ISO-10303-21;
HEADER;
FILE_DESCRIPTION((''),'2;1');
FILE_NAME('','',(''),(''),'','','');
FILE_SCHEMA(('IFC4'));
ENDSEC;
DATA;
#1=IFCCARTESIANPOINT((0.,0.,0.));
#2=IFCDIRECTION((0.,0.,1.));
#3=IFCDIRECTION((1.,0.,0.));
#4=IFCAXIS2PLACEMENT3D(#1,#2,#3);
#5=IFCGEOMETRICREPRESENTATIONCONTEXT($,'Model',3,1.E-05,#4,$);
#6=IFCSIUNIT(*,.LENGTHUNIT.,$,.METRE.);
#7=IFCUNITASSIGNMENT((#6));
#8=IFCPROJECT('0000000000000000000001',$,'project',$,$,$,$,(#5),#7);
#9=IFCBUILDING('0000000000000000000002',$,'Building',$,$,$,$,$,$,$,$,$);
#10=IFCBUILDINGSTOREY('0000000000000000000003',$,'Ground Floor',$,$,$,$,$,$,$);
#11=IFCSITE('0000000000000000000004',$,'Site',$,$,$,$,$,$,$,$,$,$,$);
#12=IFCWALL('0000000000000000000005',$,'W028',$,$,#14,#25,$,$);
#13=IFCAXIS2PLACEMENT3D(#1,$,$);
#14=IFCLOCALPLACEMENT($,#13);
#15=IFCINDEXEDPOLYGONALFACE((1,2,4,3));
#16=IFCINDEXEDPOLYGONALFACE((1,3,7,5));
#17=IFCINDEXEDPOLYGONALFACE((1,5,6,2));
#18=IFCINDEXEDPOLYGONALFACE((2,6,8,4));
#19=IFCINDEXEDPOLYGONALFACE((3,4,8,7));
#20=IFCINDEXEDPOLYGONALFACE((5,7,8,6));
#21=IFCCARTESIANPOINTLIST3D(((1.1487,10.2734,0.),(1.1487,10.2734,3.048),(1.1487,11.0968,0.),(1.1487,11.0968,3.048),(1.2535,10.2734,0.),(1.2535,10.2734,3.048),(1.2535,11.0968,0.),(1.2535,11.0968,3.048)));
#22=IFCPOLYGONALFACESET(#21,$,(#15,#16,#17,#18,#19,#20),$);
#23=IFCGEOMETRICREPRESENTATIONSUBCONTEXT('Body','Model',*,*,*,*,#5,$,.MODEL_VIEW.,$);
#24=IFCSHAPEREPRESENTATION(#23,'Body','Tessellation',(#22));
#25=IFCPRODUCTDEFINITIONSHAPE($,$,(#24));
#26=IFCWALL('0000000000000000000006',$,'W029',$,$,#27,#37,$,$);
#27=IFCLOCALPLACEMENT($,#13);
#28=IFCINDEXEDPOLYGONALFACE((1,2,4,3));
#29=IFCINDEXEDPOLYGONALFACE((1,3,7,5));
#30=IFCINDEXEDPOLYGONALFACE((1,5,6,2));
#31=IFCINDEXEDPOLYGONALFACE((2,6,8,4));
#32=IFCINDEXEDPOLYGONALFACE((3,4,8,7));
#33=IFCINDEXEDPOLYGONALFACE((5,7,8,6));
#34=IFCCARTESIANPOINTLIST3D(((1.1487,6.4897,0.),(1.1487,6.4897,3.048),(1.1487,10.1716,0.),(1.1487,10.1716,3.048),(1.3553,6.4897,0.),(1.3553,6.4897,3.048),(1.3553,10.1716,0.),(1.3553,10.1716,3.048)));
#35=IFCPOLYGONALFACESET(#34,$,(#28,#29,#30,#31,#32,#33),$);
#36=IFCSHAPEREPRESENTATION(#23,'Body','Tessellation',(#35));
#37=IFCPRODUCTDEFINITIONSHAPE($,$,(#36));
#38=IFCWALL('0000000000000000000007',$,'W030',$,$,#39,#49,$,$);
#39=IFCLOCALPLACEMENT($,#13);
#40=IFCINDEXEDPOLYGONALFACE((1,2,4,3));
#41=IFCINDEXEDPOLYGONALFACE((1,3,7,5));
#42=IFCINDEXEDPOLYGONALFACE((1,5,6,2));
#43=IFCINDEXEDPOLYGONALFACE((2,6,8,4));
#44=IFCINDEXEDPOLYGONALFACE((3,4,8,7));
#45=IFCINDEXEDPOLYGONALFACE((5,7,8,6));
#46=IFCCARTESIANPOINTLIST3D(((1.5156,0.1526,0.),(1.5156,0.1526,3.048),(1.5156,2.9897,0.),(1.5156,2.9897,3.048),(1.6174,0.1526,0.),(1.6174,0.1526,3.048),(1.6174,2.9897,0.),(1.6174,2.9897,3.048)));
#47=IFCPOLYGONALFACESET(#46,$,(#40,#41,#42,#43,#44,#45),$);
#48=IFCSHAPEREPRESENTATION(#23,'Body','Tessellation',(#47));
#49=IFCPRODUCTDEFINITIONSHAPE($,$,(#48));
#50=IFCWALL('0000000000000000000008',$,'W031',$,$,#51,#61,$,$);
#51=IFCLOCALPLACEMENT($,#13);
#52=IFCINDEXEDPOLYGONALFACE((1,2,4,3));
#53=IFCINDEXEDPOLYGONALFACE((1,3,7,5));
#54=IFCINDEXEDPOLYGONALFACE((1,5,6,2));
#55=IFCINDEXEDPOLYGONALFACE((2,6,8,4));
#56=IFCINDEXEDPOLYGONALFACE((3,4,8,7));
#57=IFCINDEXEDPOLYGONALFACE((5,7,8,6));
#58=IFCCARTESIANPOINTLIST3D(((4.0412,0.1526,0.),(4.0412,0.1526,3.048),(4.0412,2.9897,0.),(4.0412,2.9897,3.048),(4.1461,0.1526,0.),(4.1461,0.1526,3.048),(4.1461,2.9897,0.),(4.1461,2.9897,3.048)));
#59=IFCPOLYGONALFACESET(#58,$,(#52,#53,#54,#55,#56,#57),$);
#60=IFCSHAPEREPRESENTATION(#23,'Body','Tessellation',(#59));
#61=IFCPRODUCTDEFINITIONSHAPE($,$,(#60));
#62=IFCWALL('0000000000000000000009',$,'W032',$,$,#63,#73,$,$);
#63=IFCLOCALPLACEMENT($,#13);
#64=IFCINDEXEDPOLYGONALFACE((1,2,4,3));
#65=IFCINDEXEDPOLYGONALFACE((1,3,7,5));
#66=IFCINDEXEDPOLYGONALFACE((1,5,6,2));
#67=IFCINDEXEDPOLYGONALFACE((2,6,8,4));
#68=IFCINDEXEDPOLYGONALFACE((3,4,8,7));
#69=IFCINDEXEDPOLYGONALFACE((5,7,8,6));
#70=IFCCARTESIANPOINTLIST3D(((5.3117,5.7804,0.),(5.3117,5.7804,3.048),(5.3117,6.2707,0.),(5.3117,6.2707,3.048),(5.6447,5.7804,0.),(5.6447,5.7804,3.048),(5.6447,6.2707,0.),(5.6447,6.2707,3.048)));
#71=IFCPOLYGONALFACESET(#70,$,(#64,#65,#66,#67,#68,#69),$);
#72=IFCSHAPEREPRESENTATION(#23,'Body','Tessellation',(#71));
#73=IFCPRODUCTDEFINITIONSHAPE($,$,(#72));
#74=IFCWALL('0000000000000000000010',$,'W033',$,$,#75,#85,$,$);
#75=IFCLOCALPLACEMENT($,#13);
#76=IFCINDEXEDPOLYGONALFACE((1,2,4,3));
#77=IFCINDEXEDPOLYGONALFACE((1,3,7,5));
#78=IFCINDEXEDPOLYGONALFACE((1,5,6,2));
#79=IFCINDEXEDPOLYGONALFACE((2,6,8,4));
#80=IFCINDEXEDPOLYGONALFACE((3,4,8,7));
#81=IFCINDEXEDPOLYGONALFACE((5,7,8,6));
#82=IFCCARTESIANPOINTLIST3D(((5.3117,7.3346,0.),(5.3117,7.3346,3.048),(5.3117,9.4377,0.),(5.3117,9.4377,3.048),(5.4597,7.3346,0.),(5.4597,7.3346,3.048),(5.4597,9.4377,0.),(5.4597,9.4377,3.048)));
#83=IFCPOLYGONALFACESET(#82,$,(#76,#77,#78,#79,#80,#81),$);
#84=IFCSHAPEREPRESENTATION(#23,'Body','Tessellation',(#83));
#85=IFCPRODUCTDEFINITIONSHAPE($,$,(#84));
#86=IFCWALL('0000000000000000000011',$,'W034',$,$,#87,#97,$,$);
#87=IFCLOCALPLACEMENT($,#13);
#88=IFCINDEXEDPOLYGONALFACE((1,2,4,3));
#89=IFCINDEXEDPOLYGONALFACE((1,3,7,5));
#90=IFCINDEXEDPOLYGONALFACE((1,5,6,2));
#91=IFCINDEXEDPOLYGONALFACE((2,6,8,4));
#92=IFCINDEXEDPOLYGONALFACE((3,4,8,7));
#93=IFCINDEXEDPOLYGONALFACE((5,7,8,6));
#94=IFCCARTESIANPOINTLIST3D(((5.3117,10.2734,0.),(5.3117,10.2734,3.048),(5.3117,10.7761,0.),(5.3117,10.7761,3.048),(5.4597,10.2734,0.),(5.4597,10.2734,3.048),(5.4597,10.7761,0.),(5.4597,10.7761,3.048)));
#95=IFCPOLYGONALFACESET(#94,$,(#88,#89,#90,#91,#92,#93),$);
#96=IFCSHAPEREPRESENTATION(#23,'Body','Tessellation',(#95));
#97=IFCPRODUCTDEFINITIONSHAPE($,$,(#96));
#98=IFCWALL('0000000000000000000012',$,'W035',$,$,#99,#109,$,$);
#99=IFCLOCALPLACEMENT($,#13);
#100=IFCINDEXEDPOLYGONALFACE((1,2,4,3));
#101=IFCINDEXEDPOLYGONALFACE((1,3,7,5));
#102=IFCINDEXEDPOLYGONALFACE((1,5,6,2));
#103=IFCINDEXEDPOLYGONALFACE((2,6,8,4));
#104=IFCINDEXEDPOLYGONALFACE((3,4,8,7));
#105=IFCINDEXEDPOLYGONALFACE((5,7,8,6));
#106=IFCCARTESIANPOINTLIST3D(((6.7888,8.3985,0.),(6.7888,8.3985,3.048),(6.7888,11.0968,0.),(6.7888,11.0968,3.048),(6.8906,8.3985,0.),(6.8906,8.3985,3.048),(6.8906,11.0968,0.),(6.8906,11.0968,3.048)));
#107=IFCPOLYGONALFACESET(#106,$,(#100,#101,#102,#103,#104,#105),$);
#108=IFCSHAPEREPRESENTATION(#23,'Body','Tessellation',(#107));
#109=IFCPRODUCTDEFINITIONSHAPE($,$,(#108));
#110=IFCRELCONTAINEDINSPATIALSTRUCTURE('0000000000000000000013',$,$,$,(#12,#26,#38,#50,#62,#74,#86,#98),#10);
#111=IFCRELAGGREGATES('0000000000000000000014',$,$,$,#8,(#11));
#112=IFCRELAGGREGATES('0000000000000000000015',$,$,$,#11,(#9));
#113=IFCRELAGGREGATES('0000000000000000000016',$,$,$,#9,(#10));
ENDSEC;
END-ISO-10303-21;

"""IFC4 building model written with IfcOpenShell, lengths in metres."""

from ifc_helpers import new_model, si_unit, frame, origin_with_axes, place, context, subcontext, project, spatial, line, indexed_curve, outline, extrude, element, save


model = new_model("IFC4")

# Units and contexts
model_context = context("Model", 3, precision=1e-05, world=origin_with_axes())
body_context = subcontext(model_context, "Body", "Model", "MODEL_VIEW")
ifc_project = project(units=[si_unit("LENGTHUNIT", "METRE")], contexts=[model_context])

# Site, building, storey
site = spatial("IfcSite", under=ifc_project, Name="Site")
building = spatial("IfcBuilding", under=site, Name="Building")
storey = spatial("IfcBuildingStorey", under=building, Name="Ground Floor")

# Walls
wall_1_placement = place(None, frame((1.2011, 10.2734, 0.0), z_axis=(0.0, 0.0, 1.0), x_axis=(0.0, 1.0, 0.0)))
element("IfcWall", 1, at=wall_1_placement, inside=storey, Name="W028", context=body_context, shape_type="SweptSolid", body=[
    extrude(outline(indexed_curve([(0.0, -0.0524), (0.8234, -0.0524), (0.8234, 0.0524), (0.0, 0.0524)], segments=[line(1, 2, 3, 4, 1)])), origin_with_axes(), (0.0, 0.0, 1.0), 3.048),
])
wall_2_placement = place(None, frame((1.252, 6.4897, 0.0), z_axis=(0.0, 0.0, 1.0), x_axis=(0.0, 1.0, 0.0)))
element("IfcWall", 2, at=wall_2_placement, inside=storey, Name="W029", context=body_context, shape_type="SweptSolid", body=[
    extrude(outline(indexed_curve([(0.0, -0.1033), (3.682, -0.1033), (3.682, 0.1033), (0.0, 0.1033)], segments=[line(1, 2, 3, 4, 1)])), origin_with_axes(), (0.0, 0.0, 1.0), 3.048),
])
wall_3_placement = place(None, frame((1.5665, 0.1526, 0.0), z_axis=(0.0, 0.0, 1.0), x_axis=(0.0, 1.0, 0.0)))
element("IfcWall", 3, at=wall_3_placement, inside=storey, Name="W030", context=body_context, shape_type="SweptSolid", body=[
    extrude(outline(indexed_curve([(0.0, -0.0509), (2.837, -0.0509), (2.837, 0.0509), (0.0, 0.0509)], segments=[line(1, 2, 3, 4, 1)])), origin_with_axes(), (0.0, 0.0, 1.0), 3.048),
])
wall_4_placement = place(None, frame((4.0936, 0.1526, 0.0), z_axis=(0.0, 0.0, 1.0), x_axis=(0.0, 1.0, 0.0)))
element("IfcWall", 4, at=wall_4_placement, inside=storey, Name="W031", context=body_context, shape_type="SweptSolid", body=[
    extrude(outline(indexed_curve([(0.0, -0.0524), (2.837, -0.0524), (2.837, 0.0524), (0.0, 0.0524)], segments=[line(1, 2, 3, 4, 1)])), origin_with_axes(), (0.0, 0.0, 1.0), 3.048),
])
wall_5_placement = place(None, frame((5.4782, 5.7804, 0.0), z_axis=(0.0, 0.0, 1.0), x_axis=(0.0, 1.0, 0.0)))
element("IfcWall", 5, at=wall_5_placement, inside=storey, Name="W032", context=body_context, shape_type="SweptSolid", body=[
    extrude(outline(indexed_curve([(0.0, -0.1665), (0.4903, -0.1665), (0.4903, 0.1665), (0.0, 0.1665)], segments=[line(1, 2, 3, 4, 1)])), origin_with_axes(), (0.0, 0.0, 1.0), 3.048),
])
wall_6_placement = place(None, frame((5.3857, 7.3346, 0.0), z_axis=(0.0, 0.0, 1.0), x_axis=(0.0, 1.0, 0.0)))
element("IfcWall", 6, at=wall_6_placement, inside=storey, Name="W033", context=body_context, shape_type="SweptSolid", body=[
    extrude(outline(indexed_curve([(0.0, -0.074), (2.1031, -0.074), (2.1031, 0.074), (0.0, 0.074)], segments=[line(1, 2, 3, 4, 1)])), origin_with_axes(), (0.0, 0.0, 1.0), 3.048),
])
wall_7_placement = place(None, frame((5.3857, 10.2734, 0.0), z_axis=(0.0, 0.0, 1.0), x_axis=(0.0, 1.0, 0.0)))
element("IfcWall", 7, at=wall_7_placement, inside=storey, Name="W034", context=body_context, shape_type="SweptSolid", body=[
    extrude(outline(indexed_curve([(0.0, -0.074), (0.5026, -0.074), (0.5026, 0.074), (0.0, 0.074)], segments=[line(1, 2, 3, 4, 1)])), origin_with_axes(), (0.0, 0.0, 1.0), 3.048),
])
wall_8_placement = place(None, frame((6.8397, 8.3985, 0.0), z_axis=(0.0, 0.0, 1.0), x_axis=(0.0, 1.0, 0.0)))
element("IfcWall", 8, at=wall_8_placement, inside=storey, Name="W035", context=body_context, shape_type="SweptSolid", body=[
    extrude(outline(indexed_curve([(0.0, -0.0509), (2.6983, -0.0509), (2.6983, 0.0509), (0.0, 0.0509)], segments=[line(1, 2, 3, 4, 1)])), origin_with_axes(), (0.0, 0.0, 1.0), 3.048),
])

save(model, "model.ifc")
